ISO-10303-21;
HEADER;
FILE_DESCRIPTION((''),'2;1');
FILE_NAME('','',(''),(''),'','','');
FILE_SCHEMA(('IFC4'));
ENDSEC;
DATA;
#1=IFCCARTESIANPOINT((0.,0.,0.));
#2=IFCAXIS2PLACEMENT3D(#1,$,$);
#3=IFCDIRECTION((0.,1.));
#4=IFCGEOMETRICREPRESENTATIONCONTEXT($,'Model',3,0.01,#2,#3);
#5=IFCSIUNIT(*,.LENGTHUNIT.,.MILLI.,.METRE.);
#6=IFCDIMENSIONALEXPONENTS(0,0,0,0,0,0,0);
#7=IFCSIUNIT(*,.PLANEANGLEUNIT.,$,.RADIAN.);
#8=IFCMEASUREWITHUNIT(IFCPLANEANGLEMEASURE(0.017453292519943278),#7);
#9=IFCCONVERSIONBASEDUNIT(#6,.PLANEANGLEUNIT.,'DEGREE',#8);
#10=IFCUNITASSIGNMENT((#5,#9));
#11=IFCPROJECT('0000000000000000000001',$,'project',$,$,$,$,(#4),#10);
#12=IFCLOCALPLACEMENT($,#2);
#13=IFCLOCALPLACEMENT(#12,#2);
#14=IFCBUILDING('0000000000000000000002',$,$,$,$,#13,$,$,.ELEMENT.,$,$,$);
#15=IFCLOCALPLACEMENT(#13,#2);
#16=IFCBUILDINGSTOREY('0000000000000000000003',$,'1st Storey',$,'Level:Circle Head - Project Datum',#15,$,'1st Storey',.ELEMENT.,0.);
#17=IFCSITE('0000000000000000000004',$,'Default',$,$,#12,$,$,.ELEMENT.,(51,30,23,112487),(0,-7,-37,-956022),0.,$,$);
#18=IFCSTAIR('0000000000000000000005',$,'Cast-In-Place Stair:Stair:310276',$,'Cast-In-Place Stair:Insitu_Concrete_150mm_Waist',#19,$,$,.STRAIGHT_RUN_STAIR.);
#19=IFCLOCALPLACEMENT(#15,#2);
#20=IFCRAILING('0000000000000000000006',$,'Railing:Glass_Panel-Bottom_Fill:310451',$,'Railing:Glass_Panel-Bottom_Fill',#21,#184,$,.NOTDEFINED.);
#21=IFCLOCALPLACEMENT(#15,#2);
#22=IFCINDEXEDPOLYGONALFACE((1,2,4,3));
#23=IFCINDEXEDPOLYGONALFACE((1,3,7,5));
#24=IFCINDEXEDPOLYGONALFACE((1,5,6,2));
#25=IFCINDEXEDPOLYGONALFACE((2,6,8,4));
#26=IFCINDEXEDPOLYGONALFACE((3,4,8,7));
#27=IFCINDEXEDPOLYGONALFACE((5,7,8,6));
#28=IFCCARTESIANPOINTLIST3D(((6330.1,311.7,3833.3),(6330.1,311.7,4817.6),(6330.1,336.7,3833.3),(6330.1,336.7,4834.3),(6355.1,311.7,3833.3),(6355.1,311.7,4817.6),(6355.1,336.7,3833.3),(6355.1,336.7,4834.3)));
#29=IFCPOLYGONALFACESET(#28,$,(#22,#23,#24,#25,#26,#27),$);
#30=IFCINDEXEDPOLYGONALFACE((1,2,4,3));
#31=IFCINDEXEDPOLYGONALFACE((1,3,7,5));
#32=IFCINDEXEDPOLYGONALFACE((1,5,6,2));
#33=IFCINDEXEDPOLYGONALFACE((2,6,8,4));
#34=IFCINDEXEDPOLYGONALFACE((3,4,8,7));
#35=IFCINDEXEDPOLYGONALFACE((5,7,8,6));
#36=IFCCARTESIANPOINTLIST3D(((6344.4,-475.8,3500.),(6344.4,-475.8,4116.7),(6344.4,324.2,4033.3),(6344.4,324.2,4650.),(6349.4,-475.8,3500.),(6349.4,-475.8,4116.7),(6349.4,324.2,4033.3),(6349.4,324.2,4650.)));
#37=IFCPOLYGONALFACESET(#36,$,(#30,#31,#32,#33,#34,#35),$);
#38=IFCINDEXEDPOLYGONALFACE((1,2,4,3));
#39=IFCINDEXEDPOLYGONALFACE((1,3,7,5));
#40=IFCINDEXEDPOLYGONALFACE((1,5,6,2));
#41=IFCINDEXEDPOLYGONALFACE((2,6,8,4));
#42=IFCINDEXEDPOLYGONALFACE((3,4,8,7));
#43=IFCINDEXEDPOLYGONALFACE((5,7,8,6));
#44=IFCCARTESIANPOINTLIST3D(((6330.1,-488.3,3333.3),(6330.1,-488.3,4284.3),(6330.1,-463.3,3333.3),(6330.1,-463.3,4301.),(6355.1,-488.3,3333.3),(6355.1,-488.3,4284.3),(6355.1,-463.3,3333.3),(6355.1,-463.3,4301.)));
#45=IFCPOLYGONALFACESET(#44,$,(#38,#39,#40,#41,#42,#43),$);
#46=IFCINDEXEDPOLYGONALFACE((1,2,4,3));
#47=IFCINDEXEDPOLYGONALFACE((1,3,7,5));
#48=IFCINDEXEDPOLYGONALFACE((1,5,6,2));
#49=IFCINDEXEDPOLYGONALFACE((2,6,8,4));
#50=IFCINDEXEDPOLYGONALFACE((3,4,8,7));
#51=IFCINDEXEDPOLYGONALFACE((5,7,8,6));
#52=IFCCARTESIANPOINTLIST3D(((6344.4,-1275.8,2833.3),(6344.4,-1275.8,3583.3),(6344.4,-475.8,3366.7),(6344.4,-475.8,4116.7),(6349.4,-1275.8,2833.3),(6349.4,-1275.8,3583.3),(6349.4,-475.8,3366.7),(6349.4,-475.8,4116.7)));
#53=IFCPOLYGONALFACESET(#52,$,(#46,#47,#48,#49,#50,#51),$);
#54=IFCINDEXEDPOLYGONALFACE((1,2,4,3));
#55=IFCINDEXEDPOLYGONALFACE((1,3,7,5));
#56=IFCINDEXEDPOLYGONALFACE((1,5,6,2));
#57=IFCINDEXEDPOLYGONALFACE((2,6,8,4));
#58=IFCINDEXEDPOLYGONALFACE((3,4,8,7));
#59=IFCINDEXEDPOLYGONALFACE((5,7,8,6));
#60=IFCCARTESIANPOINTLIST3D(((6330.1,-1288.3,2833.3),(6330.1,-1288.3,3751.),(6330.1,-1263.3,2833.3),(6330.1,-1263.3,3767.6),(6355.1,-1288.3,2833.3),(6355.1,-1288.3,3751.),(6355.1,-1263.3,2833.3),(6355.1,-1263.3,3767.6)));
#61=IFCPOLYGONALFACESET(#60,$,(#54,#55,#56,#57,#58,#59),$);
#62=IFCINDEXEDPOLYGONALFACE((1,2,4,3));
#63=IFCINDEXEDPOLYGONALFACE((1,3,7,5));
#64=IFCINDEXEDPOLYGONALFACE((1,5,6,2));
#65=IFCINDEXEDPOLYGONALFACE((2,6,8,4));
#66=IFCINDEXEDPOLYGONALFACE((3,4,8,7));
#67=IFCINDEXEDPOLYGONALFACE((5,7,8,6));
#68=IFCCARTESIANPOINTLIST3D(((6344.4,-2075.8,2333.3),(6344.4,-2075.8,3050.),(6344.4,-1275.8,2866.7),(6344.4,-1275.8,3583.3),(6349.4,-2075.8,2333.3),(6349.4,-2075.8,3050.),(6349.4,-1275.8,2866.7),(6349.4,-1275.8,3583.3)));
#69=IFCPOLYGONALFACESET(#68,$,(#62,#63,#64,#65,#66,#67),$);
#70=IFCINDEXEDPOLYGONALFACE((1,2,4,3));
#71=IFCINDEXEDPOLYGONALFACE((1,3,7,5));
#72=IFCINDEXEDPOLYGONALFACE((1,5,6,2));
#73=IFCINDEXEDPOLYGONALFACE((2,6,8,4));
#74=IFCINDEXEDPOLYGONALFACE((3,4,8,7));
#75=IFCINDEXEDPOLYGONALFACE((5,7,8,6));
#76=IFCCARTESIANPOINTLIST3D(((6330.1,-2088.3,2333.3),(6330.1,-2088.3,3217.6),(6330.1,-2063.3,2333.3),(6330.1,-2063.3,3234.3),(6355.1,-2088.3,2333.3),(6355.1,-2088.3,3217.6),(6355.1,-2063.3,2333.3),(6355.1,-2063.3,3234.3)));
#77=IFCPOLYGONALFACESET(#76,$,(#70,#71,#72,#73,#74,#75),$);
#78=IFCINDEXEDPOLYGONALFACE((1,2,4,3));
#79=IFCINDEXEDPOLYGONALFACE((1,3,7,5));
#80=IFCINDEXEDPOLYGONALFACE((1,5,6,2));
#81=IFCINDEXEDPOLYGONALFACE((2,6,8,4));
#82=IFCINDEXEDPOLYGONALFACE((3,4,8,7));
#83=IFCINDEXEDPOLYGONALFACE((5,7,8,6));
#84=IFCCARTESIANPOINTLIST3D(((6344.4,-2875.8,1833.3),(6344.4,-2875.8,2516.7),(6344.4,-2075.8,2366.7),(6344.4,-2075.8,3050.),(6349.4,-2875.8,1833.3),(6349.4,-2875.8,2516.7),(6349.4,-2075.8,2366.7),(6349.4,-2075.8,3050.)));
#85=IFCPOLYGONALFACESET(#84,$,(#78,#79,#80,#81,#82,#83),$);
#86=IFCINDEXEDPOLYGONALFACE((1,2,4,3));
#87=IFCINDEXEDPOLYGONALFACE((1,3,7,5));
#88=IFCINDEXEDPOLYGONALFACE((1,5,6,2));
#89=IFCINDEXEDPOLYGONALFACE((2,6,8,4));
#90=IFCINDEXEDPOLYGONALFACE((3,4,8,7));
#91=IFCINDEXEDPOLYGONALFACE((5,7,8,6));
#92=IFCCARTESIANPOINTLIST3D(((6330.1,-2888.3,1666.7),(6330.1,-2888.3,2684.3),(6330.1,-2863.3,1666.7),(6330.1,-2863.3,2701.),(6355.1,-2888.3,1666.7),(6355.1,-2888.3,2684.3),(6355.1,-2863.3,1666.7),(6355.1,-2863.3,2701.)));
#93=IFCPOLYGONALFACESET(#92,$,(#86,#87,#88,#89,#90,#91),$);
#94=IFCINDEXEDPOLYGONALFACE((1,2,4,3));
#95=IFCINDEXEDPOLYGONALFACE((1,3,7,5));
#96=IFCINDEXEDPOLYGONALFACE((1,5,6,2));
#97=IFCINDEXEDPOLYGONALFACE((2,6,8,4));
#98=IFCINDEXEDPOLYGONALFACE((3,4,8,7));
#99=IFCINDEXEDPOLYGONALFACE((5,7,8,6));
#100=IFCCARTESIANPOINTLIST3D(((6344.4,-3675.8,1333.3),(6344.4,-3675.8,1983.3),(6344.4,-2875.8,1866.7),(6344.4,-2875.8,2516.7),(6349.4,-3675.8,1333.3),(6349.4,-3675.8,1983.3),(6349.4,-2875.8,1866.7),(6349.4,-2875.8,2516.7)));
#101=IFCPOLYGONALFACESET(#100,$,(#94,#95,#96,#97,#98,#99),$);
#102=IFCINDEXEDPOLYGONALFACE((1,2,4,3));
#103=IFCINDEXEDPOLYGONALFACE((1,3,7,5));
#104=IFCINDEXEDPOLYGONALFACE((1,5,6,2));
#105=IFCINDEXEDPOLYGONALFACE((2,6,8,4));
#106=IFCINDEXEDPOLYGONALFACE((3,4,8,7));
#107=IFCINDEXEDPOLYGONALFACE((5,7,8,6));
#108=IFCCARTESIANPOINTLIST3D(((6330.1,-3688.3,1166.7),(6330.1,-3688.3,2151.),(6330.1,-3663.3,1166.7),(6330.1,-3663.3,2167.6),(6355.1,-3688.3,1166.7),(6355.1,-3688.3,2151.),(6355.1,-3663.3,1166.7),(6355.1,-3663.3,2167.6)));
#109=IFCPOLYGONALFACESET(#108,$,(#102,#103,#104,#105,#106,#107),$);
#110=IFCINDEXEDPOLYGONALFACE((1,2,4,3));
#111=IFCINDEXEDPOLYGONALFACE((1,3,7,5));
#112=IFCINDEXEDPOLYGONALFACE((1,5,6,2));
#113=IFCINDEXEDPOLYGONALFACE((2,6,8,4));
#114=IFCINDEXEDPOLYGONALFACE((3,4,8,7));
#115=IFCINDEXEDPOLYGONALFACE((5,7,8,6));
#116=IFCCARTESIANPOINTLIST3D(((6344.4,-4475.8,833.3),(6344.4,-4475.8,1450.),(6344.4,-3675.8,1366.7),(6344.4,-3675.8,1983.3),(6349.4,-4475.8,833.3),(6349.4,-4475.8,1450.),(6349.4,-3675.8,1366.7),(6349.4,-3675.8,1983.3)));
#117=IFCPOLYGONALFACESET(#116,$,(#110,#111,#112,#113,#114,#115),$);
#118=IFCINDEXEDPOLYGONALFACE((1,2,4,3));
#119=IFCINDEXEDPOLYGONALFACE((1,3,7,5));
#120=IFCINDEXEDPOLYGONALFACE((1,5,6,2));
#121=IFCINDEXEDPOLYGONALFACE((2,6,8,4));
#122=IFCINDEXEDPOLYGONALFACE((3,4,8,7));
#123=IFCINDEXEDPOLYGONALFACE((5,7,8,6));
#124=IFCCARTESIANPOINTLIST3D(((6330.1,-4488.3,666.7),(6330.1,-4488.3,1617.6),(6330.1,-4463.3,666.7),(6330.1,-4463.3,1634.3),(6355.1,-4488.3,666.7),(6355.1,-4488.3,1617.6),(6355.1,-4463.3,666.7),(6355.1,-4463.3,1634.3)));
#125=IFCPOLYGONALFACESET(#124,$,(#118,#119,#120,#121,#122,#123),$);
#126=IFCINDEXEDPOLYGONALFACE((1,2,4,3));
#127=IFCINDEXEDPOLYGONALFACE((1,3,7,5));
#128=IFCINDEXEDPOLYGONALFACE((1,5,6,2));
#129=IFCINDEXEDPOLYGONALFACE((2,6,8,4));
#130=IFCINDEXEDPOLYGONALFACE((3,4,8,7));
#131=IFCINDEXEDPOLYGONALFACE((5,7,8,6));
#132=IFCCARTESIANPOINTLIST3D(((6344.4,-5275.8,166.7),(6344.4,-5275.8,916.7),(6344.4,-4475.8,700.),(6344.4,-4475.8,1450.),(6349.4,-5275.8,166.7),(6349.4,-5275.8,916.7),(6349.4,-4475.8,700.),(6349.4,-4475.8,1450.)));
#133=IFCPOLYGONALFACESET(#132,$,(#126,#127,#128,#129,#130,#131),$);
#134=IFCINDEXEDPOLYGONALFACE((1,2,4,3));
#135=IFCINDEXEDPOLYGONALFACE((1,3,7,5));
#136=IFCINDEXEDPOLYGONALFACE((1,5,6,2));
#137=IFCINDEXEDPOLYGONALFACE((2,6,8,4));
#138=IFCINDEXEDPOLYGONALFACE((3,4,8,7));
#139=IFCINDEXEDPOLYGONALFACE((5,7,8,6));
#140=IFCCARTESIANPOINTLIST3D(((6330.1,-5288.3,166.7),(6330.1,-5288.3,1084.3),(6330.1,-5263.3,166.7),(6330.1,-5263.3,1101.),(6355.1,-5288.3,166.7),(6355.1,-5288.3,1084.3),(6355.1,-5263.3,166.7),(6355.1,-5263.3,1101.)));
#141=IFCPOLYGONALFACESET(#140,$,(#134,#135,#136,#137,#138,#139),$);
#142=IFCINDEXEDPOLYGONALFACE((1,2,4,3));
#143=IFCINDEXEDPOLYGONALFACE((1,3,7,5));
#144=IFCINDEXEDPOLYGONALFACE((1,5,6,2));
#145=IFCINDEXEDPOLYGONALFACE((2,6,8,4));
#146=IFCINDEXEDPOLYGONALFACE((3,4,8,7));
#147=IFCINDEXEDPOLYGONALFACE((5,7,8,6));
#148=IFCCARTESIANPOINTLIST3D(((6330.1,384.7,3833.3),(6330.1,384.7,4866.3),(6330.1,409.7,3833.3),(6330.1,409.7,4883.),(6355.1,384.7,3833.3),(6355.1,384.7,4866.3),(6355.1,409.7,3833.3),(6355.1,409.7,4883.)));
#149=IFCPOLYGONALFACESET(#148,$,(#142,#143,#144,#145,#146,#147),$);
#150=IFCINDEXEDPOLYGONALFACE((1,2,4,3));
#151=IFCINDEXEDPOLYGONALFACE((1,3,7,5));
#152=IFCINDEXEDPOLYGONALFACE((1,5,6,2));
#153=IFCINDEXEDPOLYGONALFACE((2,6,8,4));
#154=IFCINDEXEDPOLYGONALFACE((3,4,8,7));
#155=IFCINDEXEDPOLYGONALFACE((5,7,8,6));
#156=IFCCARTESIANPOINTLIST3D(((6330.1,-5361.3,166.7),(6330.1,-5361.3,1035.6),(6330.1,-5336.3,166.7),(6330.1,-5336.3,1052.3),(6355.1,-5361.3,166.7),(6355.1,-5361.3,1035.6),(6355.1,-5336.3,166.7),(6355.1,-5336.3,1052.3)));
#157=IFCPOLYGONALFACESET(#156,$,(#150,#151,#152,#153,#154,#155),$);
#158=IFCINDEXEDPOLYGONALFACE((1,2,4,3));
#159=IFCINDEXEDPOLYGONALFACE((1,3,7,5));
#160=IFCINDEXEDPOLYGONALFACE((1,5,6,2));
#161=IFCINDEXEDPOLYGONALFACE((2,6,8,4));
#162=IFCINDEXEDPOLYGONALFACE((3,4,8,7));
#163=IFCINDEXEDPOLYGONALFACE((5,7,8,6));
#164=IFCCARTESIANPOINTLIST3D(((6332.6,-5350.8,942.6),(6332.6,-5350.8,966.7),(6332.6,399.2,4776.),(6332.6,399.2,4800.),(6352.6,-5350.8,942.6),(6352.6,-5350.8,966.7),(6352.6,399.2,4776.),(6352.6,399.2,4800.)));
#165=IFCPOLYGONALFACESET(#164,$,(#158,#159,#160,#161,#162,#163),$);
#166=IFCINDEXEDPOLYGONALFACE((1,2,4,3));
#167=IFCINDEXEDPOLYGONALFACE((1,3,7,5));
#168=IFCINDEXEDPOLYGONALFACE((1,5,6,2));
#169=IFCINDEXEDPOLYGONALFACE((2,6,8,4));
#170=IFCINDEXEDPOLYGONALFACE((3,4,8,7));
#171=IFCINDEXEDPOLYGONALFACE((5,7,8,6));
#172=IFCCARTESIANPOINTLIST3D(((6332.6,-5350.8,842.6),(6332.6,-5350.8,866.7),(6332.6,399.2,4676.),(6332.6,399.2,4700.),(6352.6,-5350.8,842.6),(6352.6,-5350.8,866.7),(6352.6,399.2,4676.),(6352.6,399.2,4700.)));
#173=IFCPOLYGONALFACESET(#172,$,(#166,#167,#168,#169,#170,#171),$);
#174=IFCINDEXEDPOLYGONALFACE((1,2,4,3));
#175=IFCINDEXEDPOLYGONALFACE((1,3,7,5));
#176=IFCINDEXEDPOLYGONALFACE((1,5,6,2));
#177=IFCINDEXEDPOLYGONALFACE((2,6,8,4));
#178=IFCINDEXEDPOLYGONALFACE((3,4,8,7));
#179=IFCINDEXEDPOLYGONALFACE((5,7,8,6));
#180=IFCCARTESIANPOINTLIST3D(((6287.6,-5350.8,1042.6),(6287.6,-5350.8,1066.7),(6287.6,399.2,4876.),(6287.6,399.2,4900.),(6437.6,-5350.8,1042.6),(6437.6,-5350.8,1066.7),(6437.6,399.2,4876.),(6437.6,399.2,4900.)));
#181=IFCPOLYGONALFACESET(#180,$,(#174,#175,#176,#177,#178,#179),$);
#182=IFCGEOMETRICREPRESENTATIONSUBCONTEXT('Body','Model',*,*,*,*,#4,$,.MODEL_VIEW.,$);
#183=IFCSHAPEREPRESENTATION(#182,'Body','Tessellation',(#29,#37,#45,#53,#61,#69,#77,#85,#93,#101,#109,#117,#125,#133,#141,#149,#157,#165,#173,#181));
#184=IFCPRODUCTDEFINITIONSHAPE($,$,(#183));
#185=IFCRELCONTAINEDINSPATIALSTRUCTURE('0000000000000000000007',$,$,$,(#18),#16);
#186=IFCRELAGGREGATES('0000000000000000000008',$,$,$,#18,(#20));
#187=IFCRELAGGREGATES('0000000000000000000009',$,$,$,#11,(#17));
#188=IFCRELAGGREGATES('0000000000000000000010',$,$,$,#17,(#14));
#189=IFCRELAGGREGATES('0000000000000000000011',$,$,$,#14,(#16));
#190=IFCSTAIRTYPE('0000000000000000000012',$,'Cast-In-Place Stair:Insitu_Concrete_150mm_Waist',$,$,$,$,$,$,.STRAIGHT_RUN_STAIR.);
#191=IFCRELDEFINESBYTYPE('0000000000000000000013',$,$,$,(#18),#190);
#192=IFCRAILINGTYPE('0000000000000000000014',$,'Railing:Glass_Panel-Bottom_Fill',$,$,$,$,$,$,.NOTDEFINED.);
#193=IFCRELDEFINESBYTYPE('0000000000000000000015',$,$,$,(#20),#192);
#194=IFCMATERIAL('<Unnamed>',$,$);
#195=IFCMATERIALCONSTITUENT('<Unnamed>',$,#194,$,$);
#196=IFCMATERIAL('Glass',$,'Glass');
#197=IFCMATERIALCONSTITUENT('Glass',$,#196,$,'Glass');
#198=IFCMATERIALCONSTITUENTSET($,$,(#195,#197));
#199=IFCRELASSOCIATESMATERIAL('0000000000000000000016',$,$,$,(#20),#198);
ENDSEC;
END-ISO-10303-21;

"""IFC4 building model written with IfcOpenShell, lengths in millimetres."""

from ifc_helpers import new_model, entity, si_unit, converted_unit, direction, frame, origin, place, context, subcontext, project, spatial, indexed_curve, outline, extrude, material, constituent, constituent_set, type_object, element, aggregate, save


model = new_model("IFC4")

# Units and contexts
model_context = context("Model", 3, precision=0.01, world=origin(), true_north=direction((0.0, 1.0)))
body_context = subcontext(model_context, "Body", "Model", "MODEL_VIEW")
ifc_project = project(units=[si_unit("LENGTHUNIT", "METRE", prefix="MILLI"), converted_unit("PLANEANGLEUNIT", "DEGREE", entity("IfcPlaneAngleMeasure", 0.017453292519943278), si_unit("PLANEANGLEUNIT", "RADIAN"), dimensions=[0, 0, 0, 0, 0, 0, 0])], contexts=[model_context])

# Site, building, storey
site_placement = place(None, origin())
site = spatial("IfcSite", under=ifc_project, at=site_placement, Name="Default", CompositionType="ELEMENT", RefLatitude=(51, 30, 23, 112487), RefLongitude=(0, -7, -37, -956022), RefElevation=0.0)
building_placement = place(site_placement, origin())
building = spatial("IfcBuilding", under=site, at=building_placement, CompositionType="ELEMENT")
storey_placement = place(building_placement, origin())
storey = spatial("IfcBuildingStorey", under=building, at=storey_placement, Name="1st Storey", ObjectType="Level:Circle Head - Project Datum", LongName="1st Storey", CompositionType="ELEMENT", Elevation=0.0)

# Shared definitions
ifc_material_1 = material(Name="<Unnamed>")

# Shared definitions
stair_type_1 = type_object("IfcStairType", Name="Cast-In-Place Stair:Insitu_Concrete_150mm_Waist", PredefinedType="STRAIGHT_RUN_STAIR")

# Stair, railing
stair_1_placement = place(storey_placement, origin())
stair_1 = element("IfcStair", 1, at=stair_1_placement, inside=storey, type_object=stair_type_1, Name="Cast-In-Place Stair:Stair:310276", ObjectType="Cast-In-Place Stair:Insitu_Concrete_150mm_Waist", PredefinedType="STRAIGHT_RUN_STAIR")
ifc_constituent_1 = constituent(ifc_material_1, Name="<Unnamed>")
ifc_material_2 = material(Name="Glass", Category="Glass")
ifc_constituent_2 = constituent(ifc_material_2, Name="Glass", Category="Glass")
ifc_constituent_set_1 = constituent_set(constituents=[ifc_constituent_1, ifc_constituent_2])
railing_type_1 = type_object("IfcRailingType", Name="Railing:Glass_Panel-Bottom_Fill", PredefinedType="NOTDEFINED")
railing_1_placement = place(stair_1_placement, frame((6287.6, -5361.3, 166.7)))
railing_1 = element("IfcRailing", 2, at=railing_1_placement, type_object=railing_type_1, material=ifc_constituent_set_1, Name="Railing:Glass_Panel-Bottom_Fill:310451", ObjectType="Railing:Glass_Panel-Bottom_Fill", PredefinedType="NOTDEFINED", context=body_context, shape_type="SweptSolid", body=[
    extrude(outline(indexed_curve([(-12.5, -496.3), (12.5, -496.3), (12.5, 504.6), (-12.5, 488.0), (-12.5, -496.3)], self_intersect=False)), frame((42.5, 5685.5, 4163.0), z_axis=(1.0, 0.0, 0.0), x_axis=(0.0, 1.0, 0.0)), (0.0, 0.0, 1.0), 25.0),
    extrude(outline(indexed_curve([(-41.7, -400.0), (575.0, -400.0), (41.7, 400.0), (-575.0, 400.0), (-41.7, -400.0)], self_intersect=False)), frame((56.7, 5285.5, 3908.3), z_axis=(1.0, 0.0, 0.0), x_axis=(0.0, 0.0, -1.0)), (0.0, 0.0, 1.0), 5.0),
    extrude(outline(indexed_curve([(-12.5, -479.6), (12.5, -479.6), (12.5, 488.0), (-12.5, 471.3), (-12.5, -479.6)], self_intersect=False)), frame((42.5, 4885.5, 3646.3), z_axis=(1.0, 0.0, 0.0), x_axis=(0.0, 1.0, 0.0)), (0.0, 0.0, 1.0), 25.0),
    extrude(outline(indexed_curve([(-108.3, -400.0), (641.7, -400.0), (108.3, 400.0), (-641.7, 400.0), (-108.3, -400.0)], self_intersect=False)), frame((56.7, 4485.5, 3308.3), z_axis=(1.0, 0.0, 0.0), x_axis=(0.0, 0.0, -1.0)), (0.0, 0.0, 1.0), 5.0),
    extrude(outline(indexed_curve([(-12.5, -463.0), (12.5, -463.0), (12.5, 471.3), (-12.5, 454.6), (-12.5, -463.0)], self_intersect=False)), frame((42.5, 4085.5, 3129.6), z_axis=(1.0, 0.0, 0.0), x_axis=(0.0, 1.0, 0.0)), (0.0, 0.0, 1.0), 25.0),
    extrude(outline(indexed_curve([(-91.7, -400.0), (625.0, -400.0), (91.7, 400.0), (-625.0, 400.0), (-91.7, -400.0)], self_intersect=False)), frame((56.7, 3685.5, 2791.7), z_axis=(1.0, 0.0, 0.0), x_axis=(0.0, 0.0, -1.0)), (0.0, 0.0, 1.0), 5.0),
    extrude(outline(indexed_curve([(-12.5, -446.3), (12.5, -446.3), (12.5, 454.6), (-12.5, 438.0), (-12.5, -446.3)], self_intersect=False)), frame((42.5, 3285.5, 2613.0), z_axis=(1.0, 0.0, 0.0), x_axis=(0.0, 1.0, 0.0)), (0.0, 0.0, 1.0), 25.0),
    extrude(outline(indexed_curve([(-75.0, -400.0), (608.3, -400.0), (75.0, 400.0), (-608.3, 400.0), (-75.0, -400.0)], self_intersect=False)), frame((56.7, 2885.5, 2275.0), z_axis=(1.0, 0.0, 0.0), x_axis=(0.0, 0.0, -1.0)), (0.0, 0.0, 1.0), 5.0),
    extrude(outline(indexed_curve([(-12.5, -513.0), (12.5, -513.0), (12.5, 521.3), (-12.5, 504.6), (-12.5, -513.0)], self_intersect=False)), frame((42.5, 2485.5, 2013.0), z_axis=(1.0, 0.0, 0.0), x_axis=(0.0, 1.0, 0.0)), (0.0, 0.0, 1.0), 25.0),
    extrude(outline(indexed_curve([(-58.3, -400.0), (591.7, -400.0), (58.3, 400.0), (-591.7, 400.0), (-58.3, -400.0)], self_intersect=False)), frame((56.7, 2085.5, 1758.3), z_axis=(1.0, 0.0, 0.0), x_axis=(0.0, 0.0, -1.0)), (0.0, 0.0, 1.0), 5.0),
    extrude(outline(indexed_curve([(-12.5, -496.3), (12.5, -496.3), (12.5, 504.6), (-12.5, 488.0), (-12.5, -496.3)], self_intersect=False)), frame((42.5, 1685.5, 1496.3), z_axis=(1.0, 0.0, 0.0), x_axis=(0.0, 1.0, 0.0)), (0.0, 0.0, 1.0), 25.0),
    extrude(outline(indexed_curve([(-41.7, -400.0), (575.0, -400.0), (41.7, 400.0), (-575.0, 400.0), (-41.7, -400.0)], self_intersect=False)), frame((56.7, 1285.5, 1241.7), z_axis=(1.0, 0.0, 0.0), x_axis=(0.0, 0.0, -1.0)), (0.0, 0.0, 1.0), 5.0),
    extrude(outline(indexed_curve([(-12.5, -479.6), (12.5, -479.6), (12.5, 488.0), (-12.5, 471.3), (-12.5, -479.6)], self_intersect=False)), frame((42.5, 885.5, 979.6), z_axis=(1.0, 0.0, 0.0), x_axis=(0.0, 1.0, 0.0)), (0.0, 0.0, 1.0), 25.0),
    extrude(outline(indexed_curve([(-108.3, -400.0), (641.7, -400.0), (108.3, 400.0), (-641.7, 400.0), (-108.3, -400.0)], self_intersect=False)), frame((56.7, 485.5, 641.7), z_axis=(1.0, 0.0, 0.0), x_axis=(0.0, 0.0, -1.0)), (0.0, 0.0, 1.0), 5.0),
    extrude(outline(indexed_curve([(-12.5, -463.0), (12.5, -463.0), (12.5, 471.3), (-12.5, 454.6), (-12.5, -463.0)], self_intersect=False)), frame((42.5, 85.5, 463.0), z_axis=(1.0, 0.0, 0.0), x_axis=(0.0, 1.0, 0.0)), (0.0, 0.0, 1.0), 25.0),
    extrude(outline(indexed_curve([(-12.5, -520.6), (12.5, -520.6), (12.5, 529.0), (-12.5, 512.3), (-12.5, -520.6)], self_intersect=False)), frame((42.5, 5758.5, 4187.3), z_axis=(1.0, 0.0, 0.0), x_axis=(0.0, 1.0, 0.0)), (0.0, 0.0, 1.0), 25.0),
    extrude(outline(indexed_curve([(-12.5, -438.6), (12.5, -438.6), (12.5, 447.0), (-12.5, 430.3), (-12.5, -438.6)], self_intersect=False)), frame((42.5, 12.5, 438.6), z_axis=(1.0, 0.0, 0.0), x_axis=(0.0, 1.0, 0.0)), (0.0, 0.0, 1.0), 25.0),
    extrude(outline(indexed_curve([(-3462.0, -10.0), (3448.7, -10.0), (3462.0, 10.0), (-3448.7, 10.0), (-3462.0, -10.0)], self_intersect=False)), frame((45.0, 2885.5, 2704.6), z_axis=(1.0, 0.0, 0.0), x_axis=(0.0, 0.83205, 0.5547)), (0.0, 0.0, 1.0), 20.0),
    extrude(outline(indexed_curve([(-3462.0, -10.0), (3448.7, -10.0), (3462.0, 10.0), (-3448.7, 10.0), (-3462.0, -10.0)], self_intersect=False)), frame((45.0, 2885.5, 2604.6), z_axis=(1.0, 0.0, 0.0), x_axis=(0.0, 0.83205, 0.5547)), (0.0, 0.0, 1.0), 20.0),
    extrude(outline(indexed_curve([(-3462.0, -10.0), (3448.7, -10.0), (3462.0, 10.0), (-3448.7, 10.0), (-3462.0, -10.0)], self_intersect=False)), frame((0.0, 2885.5, 2804.6), z_axis=(1.0, 0.0, 0.0), x_axis=(0.0, 0.83205, 0.5547)), (0.0, 0.0, 1.0), 150.0),
])
aggregate(stair_1, [railing_1])

save(model, "model.ifc")
